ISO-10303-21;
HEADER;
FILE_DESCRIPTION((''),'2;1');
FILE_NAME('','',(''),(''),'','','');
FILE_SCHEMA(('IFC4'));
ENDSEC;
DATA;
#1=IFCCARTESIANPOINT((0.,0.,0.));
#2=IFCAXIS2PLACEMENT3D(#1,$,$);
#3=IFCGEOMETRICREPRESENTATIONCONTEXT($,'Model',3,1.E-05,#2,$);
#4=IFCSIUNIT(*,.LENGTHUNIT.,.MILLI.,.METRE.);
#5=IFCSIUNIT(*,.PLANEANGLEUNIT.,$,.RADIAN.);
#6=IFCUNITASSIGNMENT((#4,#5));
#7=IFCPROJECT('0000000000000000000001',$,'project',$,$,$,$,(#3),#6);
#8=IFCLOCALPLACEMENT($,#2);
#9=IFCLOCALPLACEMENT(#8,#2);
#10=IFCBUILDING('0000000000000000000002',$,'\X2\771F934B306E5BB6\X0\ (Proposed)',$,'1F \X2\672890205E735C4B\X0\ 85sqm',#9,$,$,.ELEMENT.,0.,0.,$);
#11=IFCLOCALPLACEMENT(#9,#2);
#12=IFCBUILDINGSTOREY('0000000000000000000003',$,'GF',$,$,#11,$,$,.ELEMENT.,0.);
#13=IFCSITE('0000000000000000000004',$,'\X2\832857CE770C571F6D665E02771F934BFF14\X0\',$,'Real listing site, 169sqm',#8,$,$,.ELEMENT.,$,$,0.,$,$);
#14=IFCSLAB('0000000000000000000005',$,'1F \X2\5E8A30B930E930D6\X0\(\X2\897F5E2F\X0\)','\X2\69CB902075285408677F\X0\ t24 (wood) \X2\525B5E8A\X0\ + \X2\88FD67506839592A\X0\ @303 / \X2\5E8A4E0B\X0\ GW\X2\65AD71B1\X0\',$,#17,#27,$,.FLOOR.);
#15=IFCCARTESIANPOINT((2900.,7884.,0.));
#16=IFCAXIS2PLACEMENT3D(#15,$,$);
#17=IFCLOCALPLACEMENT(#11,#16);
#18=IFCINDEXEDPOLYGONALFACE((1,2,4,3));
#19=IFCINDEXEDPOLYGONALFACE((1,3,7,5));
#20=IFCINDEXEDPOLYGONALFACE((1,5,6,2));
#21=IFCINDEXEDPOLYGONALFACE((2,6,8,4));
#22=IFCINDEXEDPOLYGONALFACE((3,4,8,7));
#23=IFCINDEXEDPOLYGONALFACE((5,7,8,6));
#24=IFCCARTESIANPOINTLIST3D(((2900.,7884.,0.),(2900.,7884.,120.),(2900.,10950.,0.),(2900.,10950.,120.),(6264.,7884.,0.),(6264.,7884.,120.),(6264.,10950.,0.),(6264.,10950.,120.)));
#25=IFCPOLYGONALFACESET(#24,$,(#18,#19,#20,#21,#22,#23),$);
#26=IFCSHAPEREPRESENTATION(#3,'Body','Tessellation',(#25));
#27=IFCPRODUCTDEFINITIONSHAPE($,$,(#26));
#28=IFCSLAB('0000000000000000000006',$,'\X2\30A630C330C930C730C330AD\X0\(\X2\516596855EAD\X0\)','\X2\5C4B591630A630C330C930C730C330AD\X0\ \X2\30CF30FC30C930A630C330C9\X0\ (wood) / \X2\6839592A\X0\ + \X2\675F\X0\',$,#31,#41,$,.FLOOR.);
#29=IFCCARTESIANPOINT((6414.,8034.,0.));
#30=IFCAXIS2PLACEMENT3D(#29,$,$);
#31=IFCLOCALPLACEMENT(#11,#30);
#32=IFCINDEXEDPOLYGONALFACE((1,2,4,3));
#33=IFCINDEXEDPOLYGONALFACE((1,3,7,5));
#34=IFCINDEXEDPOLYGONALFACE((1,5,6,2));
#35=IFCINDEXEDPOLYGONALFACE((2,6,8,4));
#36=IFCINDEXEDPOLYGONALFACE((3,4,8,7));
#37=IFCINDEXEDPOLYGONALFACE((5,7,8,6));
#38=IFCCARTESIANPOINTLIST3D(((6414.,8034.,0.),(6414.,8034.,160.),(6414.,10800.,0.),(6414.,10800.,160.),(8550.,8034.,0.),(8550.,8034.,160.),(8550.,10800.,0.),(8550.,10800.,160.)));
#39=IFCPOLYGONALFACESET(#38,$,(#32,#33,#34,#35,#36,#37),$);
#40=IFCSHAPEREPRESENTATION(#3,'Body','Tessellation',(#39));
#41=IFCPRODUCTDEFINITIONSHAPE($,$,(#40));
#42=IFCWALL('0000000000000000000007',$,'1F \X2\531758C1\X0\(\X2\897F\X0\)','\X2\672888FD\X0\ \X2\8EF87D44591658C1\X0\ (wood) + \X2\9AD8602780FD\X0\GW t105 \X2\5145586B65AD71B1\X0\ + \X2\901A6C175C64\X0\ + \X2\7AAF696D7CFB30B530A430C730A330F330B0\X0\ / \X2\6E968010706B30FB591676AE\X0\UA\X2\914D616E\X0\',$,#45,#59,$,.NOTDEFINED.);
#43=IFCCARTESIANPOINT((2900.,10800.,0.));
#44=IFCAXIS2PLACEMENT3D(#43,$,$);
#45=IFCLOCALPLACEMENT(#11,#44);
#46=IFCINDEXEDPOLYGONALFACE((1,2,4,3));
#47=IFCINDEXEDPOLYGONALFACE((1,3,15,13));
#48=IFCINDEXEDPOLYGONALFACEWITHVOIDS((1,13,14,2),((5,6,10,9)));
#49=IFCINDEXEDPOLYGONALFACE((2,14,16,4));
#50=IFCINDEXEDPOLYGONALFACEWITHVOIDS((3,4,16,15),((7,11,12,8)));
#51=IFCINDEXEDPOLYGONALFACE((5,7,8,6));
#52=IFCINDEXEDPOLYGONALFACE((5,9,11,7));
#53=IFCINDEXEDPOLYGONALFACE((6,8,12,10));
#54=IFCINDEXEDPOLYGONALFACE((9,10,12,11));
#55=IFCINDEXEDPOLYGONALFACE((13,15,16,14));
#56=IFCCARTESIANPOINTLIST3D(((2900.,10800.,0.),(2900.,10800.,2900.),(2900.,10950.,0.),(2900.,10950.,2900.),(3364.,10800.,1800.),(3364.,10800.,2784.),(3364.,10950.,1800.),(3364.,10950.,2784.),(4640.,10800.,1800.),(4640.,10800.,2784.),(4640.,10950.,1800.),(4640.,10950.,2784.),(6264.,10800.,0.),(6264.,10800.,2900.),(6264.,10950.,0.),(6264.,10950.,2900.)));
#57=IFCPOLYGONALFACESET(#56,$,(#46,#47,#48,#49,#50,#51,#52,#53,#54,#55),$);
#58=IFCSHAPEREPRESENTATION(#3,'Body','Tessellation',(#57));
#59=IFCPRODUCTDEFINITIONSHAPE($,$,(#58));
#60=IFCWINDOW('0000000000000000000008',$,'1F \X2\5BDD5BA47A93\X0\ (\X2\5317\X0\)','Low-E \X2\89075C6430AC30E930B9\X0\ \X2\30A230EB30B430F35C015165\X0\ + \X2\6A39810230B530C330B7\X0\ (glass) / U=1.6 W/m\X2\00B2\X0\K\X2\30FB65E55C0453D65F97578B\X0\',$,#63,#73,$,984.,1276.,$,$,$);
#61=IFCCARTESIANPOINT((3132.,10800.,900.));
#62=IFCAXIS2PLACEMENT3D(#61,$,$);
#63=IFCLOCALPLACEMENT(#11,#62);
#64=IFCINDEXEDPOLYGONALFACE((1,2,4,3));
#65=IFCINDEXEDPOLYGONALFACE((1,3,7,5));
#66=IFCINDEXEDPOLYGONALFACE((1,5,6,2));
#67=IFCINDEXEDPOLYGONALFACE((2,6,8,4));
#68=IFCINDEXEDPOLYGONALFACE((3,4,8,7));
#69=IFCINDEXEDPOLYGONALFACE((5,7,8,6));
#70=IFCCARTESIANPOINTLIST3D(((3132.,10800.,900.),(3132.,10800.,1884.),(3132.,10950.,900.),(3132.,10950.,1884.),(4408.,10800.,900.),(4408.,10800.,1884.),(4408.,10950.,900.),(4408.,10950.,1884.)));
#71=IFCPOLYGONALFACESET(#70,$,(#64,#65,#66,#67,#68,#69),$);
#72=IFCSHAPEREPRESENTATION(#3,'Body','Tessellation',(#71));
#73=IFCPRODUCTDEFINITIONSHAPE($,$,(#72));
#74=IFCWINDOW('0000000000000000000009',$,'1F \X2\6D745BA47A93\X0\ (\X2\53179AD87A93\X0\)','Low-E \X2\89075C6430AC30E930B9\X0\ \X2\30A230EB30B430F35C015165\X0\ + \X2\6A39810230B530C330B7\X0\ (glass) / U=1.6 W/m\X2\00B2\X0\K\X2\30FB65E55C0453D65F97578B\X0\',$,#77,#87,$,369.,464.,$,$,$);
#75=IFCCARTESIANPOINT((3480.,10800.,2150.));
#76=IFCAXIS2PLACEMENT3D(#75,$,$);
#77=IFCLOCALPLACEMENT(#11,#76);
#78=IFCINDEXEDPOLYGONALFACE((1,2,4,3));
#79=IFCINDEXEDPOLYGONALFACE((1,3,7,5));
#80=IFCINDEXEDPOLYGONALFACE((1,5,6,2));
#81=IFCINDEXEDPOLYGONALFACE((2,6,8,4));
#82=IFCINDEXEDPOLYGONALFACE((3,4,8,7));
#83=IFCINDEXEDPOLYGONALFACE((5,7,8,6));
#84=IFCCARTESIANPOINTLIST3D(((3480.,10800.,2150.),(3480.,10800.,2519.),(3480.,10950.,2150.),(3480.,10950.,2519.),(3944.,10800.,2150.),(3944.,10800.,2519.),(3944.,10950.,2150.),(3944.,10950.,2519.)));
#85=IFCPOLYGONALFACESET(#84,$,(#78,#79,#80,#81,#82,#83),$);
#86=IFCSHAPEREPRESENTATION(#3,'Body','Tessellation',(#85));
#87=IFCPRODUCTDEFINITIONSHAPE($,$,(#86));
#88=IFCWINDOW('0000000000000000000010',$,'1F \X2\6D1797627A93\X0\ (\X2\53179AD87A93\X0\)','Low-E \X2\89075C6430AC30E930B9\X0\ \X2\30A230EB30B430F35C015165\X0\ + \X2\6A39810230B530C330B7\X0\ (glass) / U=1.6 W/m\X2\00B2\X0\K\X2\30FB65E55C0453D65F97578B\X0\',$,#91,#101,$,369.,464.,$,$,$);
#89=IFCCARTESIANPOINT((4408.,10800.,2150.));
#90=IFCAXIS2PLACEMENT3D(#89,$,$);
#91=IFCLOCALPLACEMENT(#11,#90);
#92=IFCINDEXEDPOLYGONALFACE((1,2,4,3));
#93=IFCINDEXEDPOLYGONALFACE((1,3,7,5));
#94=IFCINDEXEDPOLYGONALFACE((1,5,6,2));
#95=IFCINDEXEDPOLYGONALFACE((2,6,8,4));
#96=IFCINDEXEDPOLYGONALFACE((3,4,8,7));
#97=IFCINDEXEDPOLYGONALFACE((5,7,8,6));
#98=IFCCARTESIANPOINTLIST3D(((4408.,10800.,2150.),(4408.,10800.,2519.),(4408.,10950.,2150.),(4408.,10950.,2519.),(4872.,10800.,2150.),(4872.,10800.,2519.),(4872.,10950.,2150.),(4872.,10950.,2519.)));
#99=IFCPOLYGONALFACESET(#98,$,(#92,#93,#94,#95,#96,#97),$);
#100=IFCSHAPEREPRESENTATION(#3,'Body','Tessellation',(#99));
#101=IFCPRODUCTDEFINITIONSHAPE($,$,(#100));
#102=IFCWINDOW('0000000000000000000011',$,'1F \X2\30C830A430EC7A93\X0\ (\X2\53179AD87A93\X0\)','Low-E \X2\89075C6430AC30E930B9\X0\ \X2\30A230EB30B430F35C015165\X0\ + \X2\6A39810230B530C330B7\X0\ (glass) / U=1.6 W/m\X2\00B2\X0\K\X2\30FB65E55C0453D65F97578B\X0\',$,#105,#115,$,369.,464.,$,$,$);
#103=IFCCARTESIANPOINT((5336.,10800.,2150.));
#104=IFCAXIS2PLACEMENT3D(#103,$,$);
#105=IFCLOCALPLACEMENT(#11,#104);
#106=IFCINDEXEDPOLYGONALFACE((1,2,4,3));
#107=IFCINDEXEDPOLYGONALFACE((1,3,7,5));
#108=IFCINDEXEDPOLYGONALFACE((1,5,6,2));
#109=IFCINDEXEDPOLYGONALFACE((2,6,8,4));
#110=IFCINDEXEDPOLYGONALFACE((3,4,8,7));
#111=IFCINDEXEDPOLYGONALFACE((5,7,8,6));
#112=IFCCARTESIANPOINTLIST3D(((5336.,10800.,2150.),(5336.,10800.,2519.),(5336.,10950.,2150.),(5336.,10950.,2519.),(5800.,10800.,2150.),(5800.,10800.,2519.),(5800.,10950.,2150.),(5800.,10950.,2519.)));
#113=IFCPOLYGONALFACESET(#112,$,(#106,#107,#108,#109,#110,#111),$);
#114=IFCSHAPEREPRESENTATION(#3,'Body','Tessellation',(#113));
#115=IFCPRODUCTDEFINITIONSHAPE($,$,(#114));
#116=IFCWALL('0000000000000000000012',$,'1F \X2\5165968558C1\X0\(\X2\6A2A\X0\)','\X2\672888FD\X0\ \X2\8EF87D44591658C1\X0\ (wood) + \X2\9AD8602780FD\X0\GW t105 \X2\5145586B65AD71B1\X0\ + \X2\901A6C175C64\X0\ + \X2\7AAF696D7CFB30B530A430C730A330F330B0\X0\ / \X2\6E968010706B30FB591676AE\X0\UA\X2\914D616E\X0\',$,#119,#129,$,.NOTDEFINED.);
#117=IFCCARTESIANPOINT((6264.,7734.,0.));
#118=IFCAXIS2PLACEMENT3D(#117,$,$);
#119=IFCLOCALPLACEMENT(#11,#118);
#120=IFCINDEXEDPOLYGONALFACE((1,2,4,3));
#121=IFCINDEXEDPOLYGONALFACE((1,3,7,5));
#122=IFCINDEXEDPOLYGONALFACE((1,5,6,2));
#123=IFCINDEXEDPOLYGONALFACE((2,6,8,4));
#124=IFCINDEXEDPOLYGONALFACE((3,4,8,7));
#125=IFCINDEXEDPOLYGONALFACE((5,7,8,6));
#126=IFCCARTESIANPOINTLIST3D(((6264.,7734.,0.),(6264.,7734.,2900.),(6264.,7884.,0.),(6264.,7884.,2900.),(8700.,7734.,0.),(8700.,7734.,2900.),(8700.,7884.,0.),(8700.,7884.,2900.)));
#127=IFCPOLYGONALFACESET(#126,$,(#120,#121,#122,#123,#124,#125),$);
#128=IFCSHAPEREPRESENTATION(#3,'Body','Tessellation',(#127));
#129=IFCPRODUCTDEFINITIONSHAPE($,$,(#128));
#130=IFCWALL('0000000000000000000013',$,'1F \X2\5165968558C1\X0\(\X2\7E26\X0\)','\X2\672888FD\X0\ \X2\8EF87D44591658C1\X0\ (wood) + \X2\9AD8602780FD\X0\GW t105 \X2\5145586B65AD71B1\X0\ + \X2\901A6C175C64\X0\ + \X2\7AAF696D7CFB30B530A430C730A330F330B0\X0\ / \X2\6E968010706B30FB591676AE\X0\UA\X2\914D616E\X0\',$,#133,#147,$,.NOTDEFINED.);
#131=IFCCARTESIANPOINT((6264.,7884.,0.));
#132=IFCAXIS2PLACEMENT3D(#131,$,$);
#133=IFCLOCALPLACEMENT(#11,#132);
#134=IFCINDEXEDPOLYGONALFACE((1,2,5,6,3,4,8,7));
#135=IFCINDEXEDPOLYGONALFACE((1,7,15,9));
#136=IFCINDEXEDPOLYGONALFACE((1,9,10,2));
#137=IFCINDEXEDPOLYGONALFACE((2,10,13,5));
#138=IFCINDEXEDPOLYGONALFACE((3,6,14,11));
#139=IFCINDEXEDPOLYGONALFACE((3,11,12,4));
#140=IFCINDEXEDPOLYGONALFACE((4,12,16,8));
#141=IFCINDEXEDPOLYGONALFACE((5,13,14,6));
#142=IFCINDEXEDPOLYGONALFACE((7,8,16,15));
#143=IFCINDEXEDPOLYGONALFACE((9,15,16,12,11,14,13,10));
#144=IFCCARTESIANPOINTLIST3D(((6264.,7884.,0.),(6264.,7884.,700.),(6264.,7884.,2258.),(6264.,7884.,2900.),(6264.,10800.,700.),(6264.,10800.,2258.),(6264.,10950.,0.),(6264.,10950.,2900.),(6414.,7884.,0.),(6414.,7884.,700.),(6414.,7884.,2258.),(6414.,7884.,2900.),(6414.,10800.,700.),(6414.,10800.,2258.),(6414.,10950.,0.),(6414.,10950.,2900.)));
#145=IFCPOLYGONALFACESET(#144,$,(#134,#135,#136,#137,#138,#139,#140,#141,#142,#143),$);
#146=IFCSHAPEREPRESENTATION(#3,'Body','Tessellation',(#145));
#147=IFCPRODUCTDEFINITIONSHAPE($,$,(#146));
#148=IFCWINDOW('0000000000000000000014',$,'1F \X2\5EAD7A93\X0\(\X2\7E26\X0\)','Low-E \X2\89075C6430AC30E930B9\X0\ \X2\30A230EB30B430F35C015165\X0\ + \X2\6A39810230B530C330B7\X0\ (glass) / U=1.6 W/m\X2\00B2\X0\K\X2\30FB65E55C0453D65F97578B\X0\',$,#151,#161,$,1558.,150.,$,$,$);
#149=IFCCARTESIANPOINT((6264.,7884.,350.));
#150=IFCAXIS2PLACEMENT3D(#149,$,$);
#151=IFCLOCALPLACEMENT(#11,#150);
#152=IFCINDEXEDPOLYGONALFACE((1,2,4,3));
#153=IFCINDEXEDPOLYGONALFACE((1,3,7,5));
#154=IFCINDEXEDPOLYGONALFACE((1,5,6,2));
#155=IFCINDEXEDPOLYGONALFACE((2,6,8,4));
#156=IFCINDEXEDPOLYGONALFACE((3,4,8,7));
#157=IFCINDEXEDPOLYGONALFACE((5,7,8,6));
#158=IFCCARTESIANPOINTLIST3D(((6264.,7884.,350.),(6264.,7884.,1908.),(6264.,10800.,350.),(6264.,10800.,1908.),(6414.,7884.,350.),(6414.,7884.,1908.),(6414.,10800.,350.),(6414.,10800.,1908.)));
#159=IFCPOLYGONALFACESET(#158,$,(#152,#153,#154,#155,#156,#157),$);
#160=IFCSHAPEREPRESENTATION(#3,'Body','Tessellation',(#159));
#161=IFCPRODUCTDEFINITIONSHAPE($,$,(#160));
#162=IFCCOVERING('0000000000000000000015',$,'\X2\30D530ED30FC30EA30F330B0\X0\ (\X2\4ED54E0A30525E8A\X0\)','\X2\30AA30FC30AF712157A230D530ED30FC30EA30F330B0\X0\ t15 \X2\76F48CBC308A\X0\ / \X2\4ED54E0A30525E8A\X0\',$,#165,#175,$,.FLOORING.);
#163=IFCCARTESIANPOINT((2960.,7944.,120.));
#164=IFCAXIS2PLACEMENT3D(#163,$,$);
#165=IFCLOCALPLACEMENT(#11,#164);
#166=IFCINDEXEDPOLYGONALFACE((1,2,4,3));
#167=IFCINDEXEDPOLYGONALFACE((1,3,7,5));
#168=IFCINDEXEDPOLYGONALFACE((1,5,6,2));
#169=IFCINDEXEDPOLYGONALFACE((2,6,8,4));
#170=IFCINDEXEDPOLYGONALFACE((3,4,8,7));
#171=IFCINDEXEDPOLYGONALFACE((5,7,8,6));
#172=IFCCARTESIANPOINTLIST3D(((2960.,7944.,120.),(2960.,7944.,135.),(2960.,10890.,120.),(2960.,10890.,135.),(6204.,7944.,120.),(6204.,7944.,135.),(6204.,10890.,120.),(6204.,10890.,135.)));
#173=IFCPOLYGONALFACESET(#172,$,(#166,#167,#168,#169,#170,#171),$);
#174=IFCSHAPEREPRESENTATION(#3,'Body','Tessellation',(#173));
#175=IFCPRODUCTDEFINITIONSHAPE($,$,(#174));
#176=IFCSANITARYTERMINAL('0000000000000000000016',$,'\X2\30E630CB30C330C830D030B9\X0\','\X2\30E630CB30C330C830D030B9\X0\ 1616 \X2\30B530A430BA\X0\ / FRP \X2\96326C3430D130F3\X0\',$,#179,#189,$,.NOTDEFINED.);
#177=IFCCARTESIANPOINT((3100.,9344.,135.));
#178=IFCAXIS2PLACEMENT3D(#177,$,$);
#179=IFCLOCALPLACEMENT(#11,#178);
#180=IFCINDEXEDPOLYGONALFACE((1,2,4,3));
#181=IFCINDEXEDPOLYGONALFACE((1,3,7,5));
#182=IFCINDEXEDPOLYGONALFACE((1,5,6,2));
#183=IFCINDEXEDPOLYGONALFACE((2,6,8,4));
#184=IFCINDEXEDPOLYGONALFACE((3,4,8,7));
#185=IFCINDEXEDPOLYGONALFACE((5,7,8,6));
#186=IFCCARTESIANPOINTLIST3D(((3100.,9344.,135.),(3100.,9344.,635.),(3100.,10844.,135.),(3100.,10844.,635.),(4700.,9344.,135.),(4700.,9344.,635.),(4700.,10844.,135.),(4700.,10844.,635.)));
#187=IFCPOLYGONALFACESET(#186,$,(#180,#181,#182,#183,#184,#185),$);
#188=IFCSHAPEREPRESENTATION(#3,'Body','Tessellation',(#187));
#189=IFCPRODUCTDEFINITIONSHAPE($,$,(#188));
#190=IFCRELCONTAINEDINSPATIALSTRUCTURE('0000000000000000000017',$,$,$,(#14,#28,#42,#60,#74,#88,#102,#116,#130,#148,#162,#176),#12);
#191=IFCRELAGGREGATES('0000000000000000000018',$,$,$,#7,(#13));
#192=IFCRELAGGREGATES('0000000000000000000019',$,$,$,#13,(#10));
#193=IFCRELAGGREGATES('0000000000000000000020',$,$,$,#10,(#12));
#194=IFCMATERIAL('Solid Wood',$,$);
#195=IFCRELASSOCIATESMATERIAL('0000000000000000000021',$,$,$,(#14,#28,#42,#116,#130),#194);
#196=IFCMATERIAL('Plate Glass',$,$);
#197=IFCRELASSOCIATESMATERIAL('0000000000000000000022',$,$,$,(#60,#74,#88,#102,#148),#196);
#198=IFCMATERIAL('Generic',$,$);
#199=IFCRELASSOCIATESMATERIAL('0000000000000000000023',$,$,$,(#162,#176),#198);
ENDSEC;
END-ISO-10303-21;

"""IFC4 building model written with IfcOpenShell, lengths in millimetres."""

from ifc_helpers import new_model, si_unit, frame, frame_2d, origin, place, context, project, spatial, rectangle, extrude, material, element, fill, save


model = new_model("IFC4")

# Units and contexts
model_context = context("Model", 3, precision=1e-05, world=origin())
ifc_project = project(units=[si_unit("LENGTHUNIT", "METRE", prefix="MILLI"), si_unit("PLANEANGLEUNIT", "RADIAN")], contexts=[model_context])

# Site, building, storey
site_placement = place(None, origin())
site = spatial("IfcSite", under=ifc_project, at=site_placement, Name="茨城県土浦市真鍋４", ObjectType="Real listing site, 169sqm", CompositionType="ELEMENT", RefElevation=0.0)
building_placement = place(site_placement, origin())
building = spatial("IfcBuilding", under=site, at=building_placement, Name="真鍋の家 (Proposed)", ObjectType="1F 木造平屋 85sqm", CompositionType="ELEMENT", ElevationOfRefHeight=0.0, ElevationOfTerrain=0.0)
storey_placement = place(building_placement, origin())
storey = spatial("IfcBuildingStorey", under=building, at=storey_placement, Name="GF", CompositionType="ELEMENT", Elevation=0.0)

# Slabs
ifc_material_1 = material(Name="Solid Wood")
slab_1_placement = place(storey_placement, frame((2900.0, 7884.0, 0.0)))
element("IfcSlab", 1, at=slab_1_placement, inside=storey, material=ifc_material_1, Name="1F 床スラブ(西帯)", Description="構造用合板 t24 (wood) 剛床 + 製材根太 @303 / 床下 GW断熱", PredefinedType="FLOOR", context=model_context, shape_type="SweptSolid", body=[
    extrude(rectangle(XDim=3364.0, YDim=3066.0, at=frame_2d((1682.0, 1533.0))), frame((2900.0, 7884.0, 0.0)), (0.0, 0.0, 1.0), 120.0),
])
slab_2_placement = place(storey_placement, frame((6414.0, 8034.0, 0.0)))
element("IfcSlab", 2, at=slab_2_placement, inside=storey, material=ifc_material_1, Name="ウッドデッキ(入隅庭)", Description="屋外ウッドデッキ ハードウッド (wood) / 根太 + 束", PredefinedType="FLOOR", context=model_context, shape_type="SweptSolid", body=[
    extrude(rectangle(XDim=2136.0, YDim=2766.0, at=frame_2d((1068.0, 1383.0))), frame((6414.0, 8034.0, 0.0)), (0.0, 0.0, 1.0), 160.0),
])

# Wall, openings, windows
wall_1_placement = place(storey_placement, frame((2900.0, 10800.0, 0.0)))
wall_1 = element("IfcWall", 3, at=wall_1_placement, inside=storey, material=ifc_material_1, Name="1F 北壁(西)", Description="木製 軸組外壁 (wood) + 高性能GW t105 充填断熱 + 通気層 + 窯業系サイディング / 準耐火・外皮UA配慮", PredefinedType="NOTDEFINED", context=model_context, shape_type="SweptSolid", body=[
    extrude(rectangle(XDim=3364.0, YDim=150.0, at=frame_2d((1682.0, 75.0))), frame((2900.0, 10800.0, 0.0)), (0.0, 0.0, 1.0), 2900.0),
])
opening_1_placement = place(storey_placement, frame((3132.0, 10800.0, 900.0)))
opening_1 = element("IfcOpeningElement", 4, at=opening_1_placement, cuts=wall_1, PredefinedType="NOTDEFINED", context=model_context, shape_type="SweptSolid", body=[
    extrude(rectangle(XDim=1276.0, YDim=150.0, at=frame_2d((638.0, 75.0))), frame((3132.0, 10800.0, 900.0)), (0.0, 0.0, 1.0), 984.0),
])
opening_2_placement = place(storey_placement, frame((3480.0, 10800.0, 2150.0)))
opening_2 = element("IfcOpeningElement", 5, at=opening_2_placement, cuts=wall_1, PredefinedType="NOTDEFINED", context=model_context, shape_type="SweptSolid", body=[
    extrude(rectangle(XDim=464.0, YDim=150.0, at=frame_2d((232.0, 75.0))), frame((3480.0, 10800.0, 2150.0)), (0.0, 0.0, 1.0), 369.0),
])
opening_3_placement = place(storey_placement, frame((4408.0, 10800.0, 2150.0)))
opening_3 = element("IfcOpeningElement", 6, at=opening_3_placement, cuts=wall_1, PredefinedType="NOTDEFINED", context=model_context, shape_type="SweptSolid", body=[
    extrude(rectangle(XDim=464.0, YDim=150.0, at=frame_2d((232.0, 75.0))), frame((4408.0, 10800.0, 2150.0)), (0.0, 0.0, 1.0), 369.0),
])
opening_4_placement = place(storey_placement, frame((5336.0, 10800.0, 2150.0)))
opening_4 = element("IfcOpeningElement", 7, at=opening_4_placement, cuts=wall_1, PredefinedType="NOTDEFINED", context=model_context, shape_type="SweptSolid", body=[
    extrude(rectangle(XDim=464.0, YDim=150.0, at=frame_2d((232.0, 75.0))), frame((5336.0, 10800.0, 2150.0)), (0.0, 0.0, 1.0), 369.0),
])
ifc_material_2 = material(Name="Plate Glass")
window_1_placement = place(storey_placement, frame((3132.0, 10800.0, 900.0)))
window_1 = element("IfcWindow", 8, at=window_1_placement, inside=storey, material=ifc_material_2, Name="1F 寝室窓 (北)", Description="Low-E 複層ガラス アルゴン封入 + 樹脂サッシ (glass) / U=1.6 W/m²K・日射取得型", OverallHeight=984.0, OverallWidth=1276.0, context=model_context, shape_type="SweptSolid", body=[
    extrude(rectangle(XDim=1276.0, YDim=150.0, at=frame_2d((638.0, 75.0))), frame((3132.0, 10800.0, 900.0)), (0.0, 0.0, 1.0), 984.0),
])
fill(opening_1, window_1)
window_2_placement = place(storey_placement, frame((3480.0, 10800.0, 2150.0)))
window_2 = element("IfcWindow", 9, at=window_2_placement, inside=storey, material=ifc_material_2, Name="1F 浴室窓 (北高窓)", Description="Low-E 複層ガラス アルゴン封入 + 樹脂サッシ (glass) / U=1.6 W/m²K・日射取得型", OverallHeight=369.0, OverallWidth=464.0, context=model_context, shape_type="SweptSolid", body=[
    extrude(rectangle(XDim=464.0, YDim=150.0, at=frame_2d((232.0, 75.0))), frame((3480.0, 10800.0, 2150.0)), (0.0, 0.0, 1.0), 369.0),
])
fill(opening_2, window_2)
window_3_placement = place(storey_placement, frame((4408.0, 10800.0, 2150.0)))
window_3 = element("IfcWindow", 10, at=window_3_placement, inside=storey, material=ifc_material_2, Name="1F 洗面窓 (北高窓)", Description="Low-E 複層ガラス アルゴン封入 + 樹脂サッシ (glass) / U=1.6 W/m²K・日射取得型", OverallHeight=369.0, OverallWidth=464.0, context=model_context, shape_type="SweptSolid", body=[
    extrude(rectangle(XDim=464.0, YDim=150.0, at=frame_2d((232.0, 75.0))), frame((4408.0, 10800.0, 2150.0)), (0.0, 0.0, 1.0), 369.0),
])
fill(opening_3, window_3)
window_4_placement = place(storey_placement, frame((5336.0, 10800.0, 2150.0)))
window_4 = element("IfcWindow", 11, at=window_4_placement, inside=storey, material=ifc_material_2, Name="1F トイレ窓 (北高窓)", Description="Low-E 複層ガラス アルゴン封入 + 樹脂サッシ (glass) / U=1.6 W/m²K・日射取得型", OverallHeight=369.0, OverallWidth=464.0, context=model_context, shape_type="SweptSolid", body=[
    extrude(rectangle(XDim=464.0, YDim=150.0, at=frame_2d((232.0, 75.0))), frame((5336.0, 10800.0, 2150.0)), (0.0, 0.0, 1.0), 369.0),
])
fill(opening_4, window_4)

# Wall
wall_2_placement = place(storey_placement, frame((6264.0, 7734.0, 0.0)))
element("IfcWall", 12, at=wall_2_placement, inside=storey, material=ifc_material_1, Name="1F 入隅壁(横)", Description="木製 軸組外壁 (wood) + 高性能GW t105 充填断熱 + 通気層 + 窯業系サイディング / 準耐火・外皮UA配慮", PredefinedType="NOTDEFINED", context=model_context, shape_type="SweptSolid", body=[
    extrude(rectangle(XDim=2436.0, YDim=150.0, at=frame_2d((1218.0, 75.0))), frame((6264.0, 7734.0, 0.0)), (0.0, 0.0, 1.0), 2900.0),
])

# Wall, opening, window
wall_3_placement = place(storey_placement, frame((6264.0, 7884.0, 0.0)))
wall_3 = element("IfcWall", 13, at=wall_3_placement, inside=storey, material=ifc_material_1, Name="1F 入隅壁(縦)", Description="木製 軸組外壁 (wood) + 高性能GW t105 充填断熱 + 通気層 + 窯業系サイディング / 準耐火・外皮UA配慮", PredefinedType="NOTDEFINED", context=model_context, shape_type="SweptSolid", body=[
    extrude(rectangle(XDim=150.0, YDim=3066.0, at=frame_2d((75.0, 1533.0))), frame((6264.0, 7884.0, 0.0)), (0.0, 0.0, 1.0), 2900.0),
])
opening_5_placement = place(storey_placement, frame((6264.0, 7884.0, 350.0)))
opening_5 = element("IfcOpeningElement", 14, at=opening_5_placement, cuts=wall_3, PredefinedType="NOTDEFINED", context=model_context, shape_type="SweptSolid", body=[
    extrude(rectangle(XDim=150.0, YDim=2916.0, at=frame_2d((75.0, 1458.0))), frame((6264.0, 7884.0, 350.0)), (0.0, 0.0, 1.0), 1558.0),
])
window_5_placement = place(storey_placement, frame((6264.0, 7884.0, 350.0)))
window_5 = element("IfcWindow", 15, at=window_5_placement, inside=storey, material=ifc_material_2, Name="1F 庭窓(縦)", Description="Low-E 複層ガラス アルゴン封入 + 樹脂サッシ (glass) / U=1.6 W/m²K・日射取得型", OverallHeight=1558.0, OverallWidth=150.0, context=model_context, shape_type="SweptSolid", body=[
    extrude(rectangle(XDim=150.0, YDim=2916.0, at=frame_2d((75.0, 1458.0))), frame((6264.0, 7884.0, 350.0)), (0.0, 0.0, 1.0), 1558.0),
])
fill(opening_5, window_5)

# Covering
ifc_material_3 = material(Name="Generic")
covering_placement = place(storey_placement, frame((2960.0, 7944.0, 120.0)))
element("IfcCovering", 16, at=covering_placement, inside=storey, material=ifc_material_3, Name="フローリング (仕上げ床)", Description="オーク無垢フローリング t15 直貼り / 仕上げ床", PredefinedType="FLOORING", context=model_context, shape_type="SweptSolid", body=[
    extrude(rectangle(XDim=3244.0, YDim=2946.0, at=frame_2d((1622.0, 1473.0))), frame((2960.0, 7944.0, 120.0)), (0.0, 0.0, 1.0), 15.0),
])

# Sanitary terminal
sanitary_terminal_1_placement = place(storey_placement, frame((3100.0, 9344.0, 135.0)))
element("IfcSanitaryTerminal", 17, at=sanitary_terminal_1_placement, inside=storey, material=ifc_material_3, Name="ユニットバス", Description="ユニットバス 1616 サイズ / FRP 防水パン", PredefinedType="NOTDEFINED", context=model_context, shape_type="SweptSolid", body=[
    extrude(rectangle(XDim=1600.0, YDim=1500.0, at=frame_2d((800.0, 750.0))), frame((3100.0, 9344.0, 135.0)), (0.0, 0.0, 1.0), 500.0),
])

save(model, "model.ifc")
